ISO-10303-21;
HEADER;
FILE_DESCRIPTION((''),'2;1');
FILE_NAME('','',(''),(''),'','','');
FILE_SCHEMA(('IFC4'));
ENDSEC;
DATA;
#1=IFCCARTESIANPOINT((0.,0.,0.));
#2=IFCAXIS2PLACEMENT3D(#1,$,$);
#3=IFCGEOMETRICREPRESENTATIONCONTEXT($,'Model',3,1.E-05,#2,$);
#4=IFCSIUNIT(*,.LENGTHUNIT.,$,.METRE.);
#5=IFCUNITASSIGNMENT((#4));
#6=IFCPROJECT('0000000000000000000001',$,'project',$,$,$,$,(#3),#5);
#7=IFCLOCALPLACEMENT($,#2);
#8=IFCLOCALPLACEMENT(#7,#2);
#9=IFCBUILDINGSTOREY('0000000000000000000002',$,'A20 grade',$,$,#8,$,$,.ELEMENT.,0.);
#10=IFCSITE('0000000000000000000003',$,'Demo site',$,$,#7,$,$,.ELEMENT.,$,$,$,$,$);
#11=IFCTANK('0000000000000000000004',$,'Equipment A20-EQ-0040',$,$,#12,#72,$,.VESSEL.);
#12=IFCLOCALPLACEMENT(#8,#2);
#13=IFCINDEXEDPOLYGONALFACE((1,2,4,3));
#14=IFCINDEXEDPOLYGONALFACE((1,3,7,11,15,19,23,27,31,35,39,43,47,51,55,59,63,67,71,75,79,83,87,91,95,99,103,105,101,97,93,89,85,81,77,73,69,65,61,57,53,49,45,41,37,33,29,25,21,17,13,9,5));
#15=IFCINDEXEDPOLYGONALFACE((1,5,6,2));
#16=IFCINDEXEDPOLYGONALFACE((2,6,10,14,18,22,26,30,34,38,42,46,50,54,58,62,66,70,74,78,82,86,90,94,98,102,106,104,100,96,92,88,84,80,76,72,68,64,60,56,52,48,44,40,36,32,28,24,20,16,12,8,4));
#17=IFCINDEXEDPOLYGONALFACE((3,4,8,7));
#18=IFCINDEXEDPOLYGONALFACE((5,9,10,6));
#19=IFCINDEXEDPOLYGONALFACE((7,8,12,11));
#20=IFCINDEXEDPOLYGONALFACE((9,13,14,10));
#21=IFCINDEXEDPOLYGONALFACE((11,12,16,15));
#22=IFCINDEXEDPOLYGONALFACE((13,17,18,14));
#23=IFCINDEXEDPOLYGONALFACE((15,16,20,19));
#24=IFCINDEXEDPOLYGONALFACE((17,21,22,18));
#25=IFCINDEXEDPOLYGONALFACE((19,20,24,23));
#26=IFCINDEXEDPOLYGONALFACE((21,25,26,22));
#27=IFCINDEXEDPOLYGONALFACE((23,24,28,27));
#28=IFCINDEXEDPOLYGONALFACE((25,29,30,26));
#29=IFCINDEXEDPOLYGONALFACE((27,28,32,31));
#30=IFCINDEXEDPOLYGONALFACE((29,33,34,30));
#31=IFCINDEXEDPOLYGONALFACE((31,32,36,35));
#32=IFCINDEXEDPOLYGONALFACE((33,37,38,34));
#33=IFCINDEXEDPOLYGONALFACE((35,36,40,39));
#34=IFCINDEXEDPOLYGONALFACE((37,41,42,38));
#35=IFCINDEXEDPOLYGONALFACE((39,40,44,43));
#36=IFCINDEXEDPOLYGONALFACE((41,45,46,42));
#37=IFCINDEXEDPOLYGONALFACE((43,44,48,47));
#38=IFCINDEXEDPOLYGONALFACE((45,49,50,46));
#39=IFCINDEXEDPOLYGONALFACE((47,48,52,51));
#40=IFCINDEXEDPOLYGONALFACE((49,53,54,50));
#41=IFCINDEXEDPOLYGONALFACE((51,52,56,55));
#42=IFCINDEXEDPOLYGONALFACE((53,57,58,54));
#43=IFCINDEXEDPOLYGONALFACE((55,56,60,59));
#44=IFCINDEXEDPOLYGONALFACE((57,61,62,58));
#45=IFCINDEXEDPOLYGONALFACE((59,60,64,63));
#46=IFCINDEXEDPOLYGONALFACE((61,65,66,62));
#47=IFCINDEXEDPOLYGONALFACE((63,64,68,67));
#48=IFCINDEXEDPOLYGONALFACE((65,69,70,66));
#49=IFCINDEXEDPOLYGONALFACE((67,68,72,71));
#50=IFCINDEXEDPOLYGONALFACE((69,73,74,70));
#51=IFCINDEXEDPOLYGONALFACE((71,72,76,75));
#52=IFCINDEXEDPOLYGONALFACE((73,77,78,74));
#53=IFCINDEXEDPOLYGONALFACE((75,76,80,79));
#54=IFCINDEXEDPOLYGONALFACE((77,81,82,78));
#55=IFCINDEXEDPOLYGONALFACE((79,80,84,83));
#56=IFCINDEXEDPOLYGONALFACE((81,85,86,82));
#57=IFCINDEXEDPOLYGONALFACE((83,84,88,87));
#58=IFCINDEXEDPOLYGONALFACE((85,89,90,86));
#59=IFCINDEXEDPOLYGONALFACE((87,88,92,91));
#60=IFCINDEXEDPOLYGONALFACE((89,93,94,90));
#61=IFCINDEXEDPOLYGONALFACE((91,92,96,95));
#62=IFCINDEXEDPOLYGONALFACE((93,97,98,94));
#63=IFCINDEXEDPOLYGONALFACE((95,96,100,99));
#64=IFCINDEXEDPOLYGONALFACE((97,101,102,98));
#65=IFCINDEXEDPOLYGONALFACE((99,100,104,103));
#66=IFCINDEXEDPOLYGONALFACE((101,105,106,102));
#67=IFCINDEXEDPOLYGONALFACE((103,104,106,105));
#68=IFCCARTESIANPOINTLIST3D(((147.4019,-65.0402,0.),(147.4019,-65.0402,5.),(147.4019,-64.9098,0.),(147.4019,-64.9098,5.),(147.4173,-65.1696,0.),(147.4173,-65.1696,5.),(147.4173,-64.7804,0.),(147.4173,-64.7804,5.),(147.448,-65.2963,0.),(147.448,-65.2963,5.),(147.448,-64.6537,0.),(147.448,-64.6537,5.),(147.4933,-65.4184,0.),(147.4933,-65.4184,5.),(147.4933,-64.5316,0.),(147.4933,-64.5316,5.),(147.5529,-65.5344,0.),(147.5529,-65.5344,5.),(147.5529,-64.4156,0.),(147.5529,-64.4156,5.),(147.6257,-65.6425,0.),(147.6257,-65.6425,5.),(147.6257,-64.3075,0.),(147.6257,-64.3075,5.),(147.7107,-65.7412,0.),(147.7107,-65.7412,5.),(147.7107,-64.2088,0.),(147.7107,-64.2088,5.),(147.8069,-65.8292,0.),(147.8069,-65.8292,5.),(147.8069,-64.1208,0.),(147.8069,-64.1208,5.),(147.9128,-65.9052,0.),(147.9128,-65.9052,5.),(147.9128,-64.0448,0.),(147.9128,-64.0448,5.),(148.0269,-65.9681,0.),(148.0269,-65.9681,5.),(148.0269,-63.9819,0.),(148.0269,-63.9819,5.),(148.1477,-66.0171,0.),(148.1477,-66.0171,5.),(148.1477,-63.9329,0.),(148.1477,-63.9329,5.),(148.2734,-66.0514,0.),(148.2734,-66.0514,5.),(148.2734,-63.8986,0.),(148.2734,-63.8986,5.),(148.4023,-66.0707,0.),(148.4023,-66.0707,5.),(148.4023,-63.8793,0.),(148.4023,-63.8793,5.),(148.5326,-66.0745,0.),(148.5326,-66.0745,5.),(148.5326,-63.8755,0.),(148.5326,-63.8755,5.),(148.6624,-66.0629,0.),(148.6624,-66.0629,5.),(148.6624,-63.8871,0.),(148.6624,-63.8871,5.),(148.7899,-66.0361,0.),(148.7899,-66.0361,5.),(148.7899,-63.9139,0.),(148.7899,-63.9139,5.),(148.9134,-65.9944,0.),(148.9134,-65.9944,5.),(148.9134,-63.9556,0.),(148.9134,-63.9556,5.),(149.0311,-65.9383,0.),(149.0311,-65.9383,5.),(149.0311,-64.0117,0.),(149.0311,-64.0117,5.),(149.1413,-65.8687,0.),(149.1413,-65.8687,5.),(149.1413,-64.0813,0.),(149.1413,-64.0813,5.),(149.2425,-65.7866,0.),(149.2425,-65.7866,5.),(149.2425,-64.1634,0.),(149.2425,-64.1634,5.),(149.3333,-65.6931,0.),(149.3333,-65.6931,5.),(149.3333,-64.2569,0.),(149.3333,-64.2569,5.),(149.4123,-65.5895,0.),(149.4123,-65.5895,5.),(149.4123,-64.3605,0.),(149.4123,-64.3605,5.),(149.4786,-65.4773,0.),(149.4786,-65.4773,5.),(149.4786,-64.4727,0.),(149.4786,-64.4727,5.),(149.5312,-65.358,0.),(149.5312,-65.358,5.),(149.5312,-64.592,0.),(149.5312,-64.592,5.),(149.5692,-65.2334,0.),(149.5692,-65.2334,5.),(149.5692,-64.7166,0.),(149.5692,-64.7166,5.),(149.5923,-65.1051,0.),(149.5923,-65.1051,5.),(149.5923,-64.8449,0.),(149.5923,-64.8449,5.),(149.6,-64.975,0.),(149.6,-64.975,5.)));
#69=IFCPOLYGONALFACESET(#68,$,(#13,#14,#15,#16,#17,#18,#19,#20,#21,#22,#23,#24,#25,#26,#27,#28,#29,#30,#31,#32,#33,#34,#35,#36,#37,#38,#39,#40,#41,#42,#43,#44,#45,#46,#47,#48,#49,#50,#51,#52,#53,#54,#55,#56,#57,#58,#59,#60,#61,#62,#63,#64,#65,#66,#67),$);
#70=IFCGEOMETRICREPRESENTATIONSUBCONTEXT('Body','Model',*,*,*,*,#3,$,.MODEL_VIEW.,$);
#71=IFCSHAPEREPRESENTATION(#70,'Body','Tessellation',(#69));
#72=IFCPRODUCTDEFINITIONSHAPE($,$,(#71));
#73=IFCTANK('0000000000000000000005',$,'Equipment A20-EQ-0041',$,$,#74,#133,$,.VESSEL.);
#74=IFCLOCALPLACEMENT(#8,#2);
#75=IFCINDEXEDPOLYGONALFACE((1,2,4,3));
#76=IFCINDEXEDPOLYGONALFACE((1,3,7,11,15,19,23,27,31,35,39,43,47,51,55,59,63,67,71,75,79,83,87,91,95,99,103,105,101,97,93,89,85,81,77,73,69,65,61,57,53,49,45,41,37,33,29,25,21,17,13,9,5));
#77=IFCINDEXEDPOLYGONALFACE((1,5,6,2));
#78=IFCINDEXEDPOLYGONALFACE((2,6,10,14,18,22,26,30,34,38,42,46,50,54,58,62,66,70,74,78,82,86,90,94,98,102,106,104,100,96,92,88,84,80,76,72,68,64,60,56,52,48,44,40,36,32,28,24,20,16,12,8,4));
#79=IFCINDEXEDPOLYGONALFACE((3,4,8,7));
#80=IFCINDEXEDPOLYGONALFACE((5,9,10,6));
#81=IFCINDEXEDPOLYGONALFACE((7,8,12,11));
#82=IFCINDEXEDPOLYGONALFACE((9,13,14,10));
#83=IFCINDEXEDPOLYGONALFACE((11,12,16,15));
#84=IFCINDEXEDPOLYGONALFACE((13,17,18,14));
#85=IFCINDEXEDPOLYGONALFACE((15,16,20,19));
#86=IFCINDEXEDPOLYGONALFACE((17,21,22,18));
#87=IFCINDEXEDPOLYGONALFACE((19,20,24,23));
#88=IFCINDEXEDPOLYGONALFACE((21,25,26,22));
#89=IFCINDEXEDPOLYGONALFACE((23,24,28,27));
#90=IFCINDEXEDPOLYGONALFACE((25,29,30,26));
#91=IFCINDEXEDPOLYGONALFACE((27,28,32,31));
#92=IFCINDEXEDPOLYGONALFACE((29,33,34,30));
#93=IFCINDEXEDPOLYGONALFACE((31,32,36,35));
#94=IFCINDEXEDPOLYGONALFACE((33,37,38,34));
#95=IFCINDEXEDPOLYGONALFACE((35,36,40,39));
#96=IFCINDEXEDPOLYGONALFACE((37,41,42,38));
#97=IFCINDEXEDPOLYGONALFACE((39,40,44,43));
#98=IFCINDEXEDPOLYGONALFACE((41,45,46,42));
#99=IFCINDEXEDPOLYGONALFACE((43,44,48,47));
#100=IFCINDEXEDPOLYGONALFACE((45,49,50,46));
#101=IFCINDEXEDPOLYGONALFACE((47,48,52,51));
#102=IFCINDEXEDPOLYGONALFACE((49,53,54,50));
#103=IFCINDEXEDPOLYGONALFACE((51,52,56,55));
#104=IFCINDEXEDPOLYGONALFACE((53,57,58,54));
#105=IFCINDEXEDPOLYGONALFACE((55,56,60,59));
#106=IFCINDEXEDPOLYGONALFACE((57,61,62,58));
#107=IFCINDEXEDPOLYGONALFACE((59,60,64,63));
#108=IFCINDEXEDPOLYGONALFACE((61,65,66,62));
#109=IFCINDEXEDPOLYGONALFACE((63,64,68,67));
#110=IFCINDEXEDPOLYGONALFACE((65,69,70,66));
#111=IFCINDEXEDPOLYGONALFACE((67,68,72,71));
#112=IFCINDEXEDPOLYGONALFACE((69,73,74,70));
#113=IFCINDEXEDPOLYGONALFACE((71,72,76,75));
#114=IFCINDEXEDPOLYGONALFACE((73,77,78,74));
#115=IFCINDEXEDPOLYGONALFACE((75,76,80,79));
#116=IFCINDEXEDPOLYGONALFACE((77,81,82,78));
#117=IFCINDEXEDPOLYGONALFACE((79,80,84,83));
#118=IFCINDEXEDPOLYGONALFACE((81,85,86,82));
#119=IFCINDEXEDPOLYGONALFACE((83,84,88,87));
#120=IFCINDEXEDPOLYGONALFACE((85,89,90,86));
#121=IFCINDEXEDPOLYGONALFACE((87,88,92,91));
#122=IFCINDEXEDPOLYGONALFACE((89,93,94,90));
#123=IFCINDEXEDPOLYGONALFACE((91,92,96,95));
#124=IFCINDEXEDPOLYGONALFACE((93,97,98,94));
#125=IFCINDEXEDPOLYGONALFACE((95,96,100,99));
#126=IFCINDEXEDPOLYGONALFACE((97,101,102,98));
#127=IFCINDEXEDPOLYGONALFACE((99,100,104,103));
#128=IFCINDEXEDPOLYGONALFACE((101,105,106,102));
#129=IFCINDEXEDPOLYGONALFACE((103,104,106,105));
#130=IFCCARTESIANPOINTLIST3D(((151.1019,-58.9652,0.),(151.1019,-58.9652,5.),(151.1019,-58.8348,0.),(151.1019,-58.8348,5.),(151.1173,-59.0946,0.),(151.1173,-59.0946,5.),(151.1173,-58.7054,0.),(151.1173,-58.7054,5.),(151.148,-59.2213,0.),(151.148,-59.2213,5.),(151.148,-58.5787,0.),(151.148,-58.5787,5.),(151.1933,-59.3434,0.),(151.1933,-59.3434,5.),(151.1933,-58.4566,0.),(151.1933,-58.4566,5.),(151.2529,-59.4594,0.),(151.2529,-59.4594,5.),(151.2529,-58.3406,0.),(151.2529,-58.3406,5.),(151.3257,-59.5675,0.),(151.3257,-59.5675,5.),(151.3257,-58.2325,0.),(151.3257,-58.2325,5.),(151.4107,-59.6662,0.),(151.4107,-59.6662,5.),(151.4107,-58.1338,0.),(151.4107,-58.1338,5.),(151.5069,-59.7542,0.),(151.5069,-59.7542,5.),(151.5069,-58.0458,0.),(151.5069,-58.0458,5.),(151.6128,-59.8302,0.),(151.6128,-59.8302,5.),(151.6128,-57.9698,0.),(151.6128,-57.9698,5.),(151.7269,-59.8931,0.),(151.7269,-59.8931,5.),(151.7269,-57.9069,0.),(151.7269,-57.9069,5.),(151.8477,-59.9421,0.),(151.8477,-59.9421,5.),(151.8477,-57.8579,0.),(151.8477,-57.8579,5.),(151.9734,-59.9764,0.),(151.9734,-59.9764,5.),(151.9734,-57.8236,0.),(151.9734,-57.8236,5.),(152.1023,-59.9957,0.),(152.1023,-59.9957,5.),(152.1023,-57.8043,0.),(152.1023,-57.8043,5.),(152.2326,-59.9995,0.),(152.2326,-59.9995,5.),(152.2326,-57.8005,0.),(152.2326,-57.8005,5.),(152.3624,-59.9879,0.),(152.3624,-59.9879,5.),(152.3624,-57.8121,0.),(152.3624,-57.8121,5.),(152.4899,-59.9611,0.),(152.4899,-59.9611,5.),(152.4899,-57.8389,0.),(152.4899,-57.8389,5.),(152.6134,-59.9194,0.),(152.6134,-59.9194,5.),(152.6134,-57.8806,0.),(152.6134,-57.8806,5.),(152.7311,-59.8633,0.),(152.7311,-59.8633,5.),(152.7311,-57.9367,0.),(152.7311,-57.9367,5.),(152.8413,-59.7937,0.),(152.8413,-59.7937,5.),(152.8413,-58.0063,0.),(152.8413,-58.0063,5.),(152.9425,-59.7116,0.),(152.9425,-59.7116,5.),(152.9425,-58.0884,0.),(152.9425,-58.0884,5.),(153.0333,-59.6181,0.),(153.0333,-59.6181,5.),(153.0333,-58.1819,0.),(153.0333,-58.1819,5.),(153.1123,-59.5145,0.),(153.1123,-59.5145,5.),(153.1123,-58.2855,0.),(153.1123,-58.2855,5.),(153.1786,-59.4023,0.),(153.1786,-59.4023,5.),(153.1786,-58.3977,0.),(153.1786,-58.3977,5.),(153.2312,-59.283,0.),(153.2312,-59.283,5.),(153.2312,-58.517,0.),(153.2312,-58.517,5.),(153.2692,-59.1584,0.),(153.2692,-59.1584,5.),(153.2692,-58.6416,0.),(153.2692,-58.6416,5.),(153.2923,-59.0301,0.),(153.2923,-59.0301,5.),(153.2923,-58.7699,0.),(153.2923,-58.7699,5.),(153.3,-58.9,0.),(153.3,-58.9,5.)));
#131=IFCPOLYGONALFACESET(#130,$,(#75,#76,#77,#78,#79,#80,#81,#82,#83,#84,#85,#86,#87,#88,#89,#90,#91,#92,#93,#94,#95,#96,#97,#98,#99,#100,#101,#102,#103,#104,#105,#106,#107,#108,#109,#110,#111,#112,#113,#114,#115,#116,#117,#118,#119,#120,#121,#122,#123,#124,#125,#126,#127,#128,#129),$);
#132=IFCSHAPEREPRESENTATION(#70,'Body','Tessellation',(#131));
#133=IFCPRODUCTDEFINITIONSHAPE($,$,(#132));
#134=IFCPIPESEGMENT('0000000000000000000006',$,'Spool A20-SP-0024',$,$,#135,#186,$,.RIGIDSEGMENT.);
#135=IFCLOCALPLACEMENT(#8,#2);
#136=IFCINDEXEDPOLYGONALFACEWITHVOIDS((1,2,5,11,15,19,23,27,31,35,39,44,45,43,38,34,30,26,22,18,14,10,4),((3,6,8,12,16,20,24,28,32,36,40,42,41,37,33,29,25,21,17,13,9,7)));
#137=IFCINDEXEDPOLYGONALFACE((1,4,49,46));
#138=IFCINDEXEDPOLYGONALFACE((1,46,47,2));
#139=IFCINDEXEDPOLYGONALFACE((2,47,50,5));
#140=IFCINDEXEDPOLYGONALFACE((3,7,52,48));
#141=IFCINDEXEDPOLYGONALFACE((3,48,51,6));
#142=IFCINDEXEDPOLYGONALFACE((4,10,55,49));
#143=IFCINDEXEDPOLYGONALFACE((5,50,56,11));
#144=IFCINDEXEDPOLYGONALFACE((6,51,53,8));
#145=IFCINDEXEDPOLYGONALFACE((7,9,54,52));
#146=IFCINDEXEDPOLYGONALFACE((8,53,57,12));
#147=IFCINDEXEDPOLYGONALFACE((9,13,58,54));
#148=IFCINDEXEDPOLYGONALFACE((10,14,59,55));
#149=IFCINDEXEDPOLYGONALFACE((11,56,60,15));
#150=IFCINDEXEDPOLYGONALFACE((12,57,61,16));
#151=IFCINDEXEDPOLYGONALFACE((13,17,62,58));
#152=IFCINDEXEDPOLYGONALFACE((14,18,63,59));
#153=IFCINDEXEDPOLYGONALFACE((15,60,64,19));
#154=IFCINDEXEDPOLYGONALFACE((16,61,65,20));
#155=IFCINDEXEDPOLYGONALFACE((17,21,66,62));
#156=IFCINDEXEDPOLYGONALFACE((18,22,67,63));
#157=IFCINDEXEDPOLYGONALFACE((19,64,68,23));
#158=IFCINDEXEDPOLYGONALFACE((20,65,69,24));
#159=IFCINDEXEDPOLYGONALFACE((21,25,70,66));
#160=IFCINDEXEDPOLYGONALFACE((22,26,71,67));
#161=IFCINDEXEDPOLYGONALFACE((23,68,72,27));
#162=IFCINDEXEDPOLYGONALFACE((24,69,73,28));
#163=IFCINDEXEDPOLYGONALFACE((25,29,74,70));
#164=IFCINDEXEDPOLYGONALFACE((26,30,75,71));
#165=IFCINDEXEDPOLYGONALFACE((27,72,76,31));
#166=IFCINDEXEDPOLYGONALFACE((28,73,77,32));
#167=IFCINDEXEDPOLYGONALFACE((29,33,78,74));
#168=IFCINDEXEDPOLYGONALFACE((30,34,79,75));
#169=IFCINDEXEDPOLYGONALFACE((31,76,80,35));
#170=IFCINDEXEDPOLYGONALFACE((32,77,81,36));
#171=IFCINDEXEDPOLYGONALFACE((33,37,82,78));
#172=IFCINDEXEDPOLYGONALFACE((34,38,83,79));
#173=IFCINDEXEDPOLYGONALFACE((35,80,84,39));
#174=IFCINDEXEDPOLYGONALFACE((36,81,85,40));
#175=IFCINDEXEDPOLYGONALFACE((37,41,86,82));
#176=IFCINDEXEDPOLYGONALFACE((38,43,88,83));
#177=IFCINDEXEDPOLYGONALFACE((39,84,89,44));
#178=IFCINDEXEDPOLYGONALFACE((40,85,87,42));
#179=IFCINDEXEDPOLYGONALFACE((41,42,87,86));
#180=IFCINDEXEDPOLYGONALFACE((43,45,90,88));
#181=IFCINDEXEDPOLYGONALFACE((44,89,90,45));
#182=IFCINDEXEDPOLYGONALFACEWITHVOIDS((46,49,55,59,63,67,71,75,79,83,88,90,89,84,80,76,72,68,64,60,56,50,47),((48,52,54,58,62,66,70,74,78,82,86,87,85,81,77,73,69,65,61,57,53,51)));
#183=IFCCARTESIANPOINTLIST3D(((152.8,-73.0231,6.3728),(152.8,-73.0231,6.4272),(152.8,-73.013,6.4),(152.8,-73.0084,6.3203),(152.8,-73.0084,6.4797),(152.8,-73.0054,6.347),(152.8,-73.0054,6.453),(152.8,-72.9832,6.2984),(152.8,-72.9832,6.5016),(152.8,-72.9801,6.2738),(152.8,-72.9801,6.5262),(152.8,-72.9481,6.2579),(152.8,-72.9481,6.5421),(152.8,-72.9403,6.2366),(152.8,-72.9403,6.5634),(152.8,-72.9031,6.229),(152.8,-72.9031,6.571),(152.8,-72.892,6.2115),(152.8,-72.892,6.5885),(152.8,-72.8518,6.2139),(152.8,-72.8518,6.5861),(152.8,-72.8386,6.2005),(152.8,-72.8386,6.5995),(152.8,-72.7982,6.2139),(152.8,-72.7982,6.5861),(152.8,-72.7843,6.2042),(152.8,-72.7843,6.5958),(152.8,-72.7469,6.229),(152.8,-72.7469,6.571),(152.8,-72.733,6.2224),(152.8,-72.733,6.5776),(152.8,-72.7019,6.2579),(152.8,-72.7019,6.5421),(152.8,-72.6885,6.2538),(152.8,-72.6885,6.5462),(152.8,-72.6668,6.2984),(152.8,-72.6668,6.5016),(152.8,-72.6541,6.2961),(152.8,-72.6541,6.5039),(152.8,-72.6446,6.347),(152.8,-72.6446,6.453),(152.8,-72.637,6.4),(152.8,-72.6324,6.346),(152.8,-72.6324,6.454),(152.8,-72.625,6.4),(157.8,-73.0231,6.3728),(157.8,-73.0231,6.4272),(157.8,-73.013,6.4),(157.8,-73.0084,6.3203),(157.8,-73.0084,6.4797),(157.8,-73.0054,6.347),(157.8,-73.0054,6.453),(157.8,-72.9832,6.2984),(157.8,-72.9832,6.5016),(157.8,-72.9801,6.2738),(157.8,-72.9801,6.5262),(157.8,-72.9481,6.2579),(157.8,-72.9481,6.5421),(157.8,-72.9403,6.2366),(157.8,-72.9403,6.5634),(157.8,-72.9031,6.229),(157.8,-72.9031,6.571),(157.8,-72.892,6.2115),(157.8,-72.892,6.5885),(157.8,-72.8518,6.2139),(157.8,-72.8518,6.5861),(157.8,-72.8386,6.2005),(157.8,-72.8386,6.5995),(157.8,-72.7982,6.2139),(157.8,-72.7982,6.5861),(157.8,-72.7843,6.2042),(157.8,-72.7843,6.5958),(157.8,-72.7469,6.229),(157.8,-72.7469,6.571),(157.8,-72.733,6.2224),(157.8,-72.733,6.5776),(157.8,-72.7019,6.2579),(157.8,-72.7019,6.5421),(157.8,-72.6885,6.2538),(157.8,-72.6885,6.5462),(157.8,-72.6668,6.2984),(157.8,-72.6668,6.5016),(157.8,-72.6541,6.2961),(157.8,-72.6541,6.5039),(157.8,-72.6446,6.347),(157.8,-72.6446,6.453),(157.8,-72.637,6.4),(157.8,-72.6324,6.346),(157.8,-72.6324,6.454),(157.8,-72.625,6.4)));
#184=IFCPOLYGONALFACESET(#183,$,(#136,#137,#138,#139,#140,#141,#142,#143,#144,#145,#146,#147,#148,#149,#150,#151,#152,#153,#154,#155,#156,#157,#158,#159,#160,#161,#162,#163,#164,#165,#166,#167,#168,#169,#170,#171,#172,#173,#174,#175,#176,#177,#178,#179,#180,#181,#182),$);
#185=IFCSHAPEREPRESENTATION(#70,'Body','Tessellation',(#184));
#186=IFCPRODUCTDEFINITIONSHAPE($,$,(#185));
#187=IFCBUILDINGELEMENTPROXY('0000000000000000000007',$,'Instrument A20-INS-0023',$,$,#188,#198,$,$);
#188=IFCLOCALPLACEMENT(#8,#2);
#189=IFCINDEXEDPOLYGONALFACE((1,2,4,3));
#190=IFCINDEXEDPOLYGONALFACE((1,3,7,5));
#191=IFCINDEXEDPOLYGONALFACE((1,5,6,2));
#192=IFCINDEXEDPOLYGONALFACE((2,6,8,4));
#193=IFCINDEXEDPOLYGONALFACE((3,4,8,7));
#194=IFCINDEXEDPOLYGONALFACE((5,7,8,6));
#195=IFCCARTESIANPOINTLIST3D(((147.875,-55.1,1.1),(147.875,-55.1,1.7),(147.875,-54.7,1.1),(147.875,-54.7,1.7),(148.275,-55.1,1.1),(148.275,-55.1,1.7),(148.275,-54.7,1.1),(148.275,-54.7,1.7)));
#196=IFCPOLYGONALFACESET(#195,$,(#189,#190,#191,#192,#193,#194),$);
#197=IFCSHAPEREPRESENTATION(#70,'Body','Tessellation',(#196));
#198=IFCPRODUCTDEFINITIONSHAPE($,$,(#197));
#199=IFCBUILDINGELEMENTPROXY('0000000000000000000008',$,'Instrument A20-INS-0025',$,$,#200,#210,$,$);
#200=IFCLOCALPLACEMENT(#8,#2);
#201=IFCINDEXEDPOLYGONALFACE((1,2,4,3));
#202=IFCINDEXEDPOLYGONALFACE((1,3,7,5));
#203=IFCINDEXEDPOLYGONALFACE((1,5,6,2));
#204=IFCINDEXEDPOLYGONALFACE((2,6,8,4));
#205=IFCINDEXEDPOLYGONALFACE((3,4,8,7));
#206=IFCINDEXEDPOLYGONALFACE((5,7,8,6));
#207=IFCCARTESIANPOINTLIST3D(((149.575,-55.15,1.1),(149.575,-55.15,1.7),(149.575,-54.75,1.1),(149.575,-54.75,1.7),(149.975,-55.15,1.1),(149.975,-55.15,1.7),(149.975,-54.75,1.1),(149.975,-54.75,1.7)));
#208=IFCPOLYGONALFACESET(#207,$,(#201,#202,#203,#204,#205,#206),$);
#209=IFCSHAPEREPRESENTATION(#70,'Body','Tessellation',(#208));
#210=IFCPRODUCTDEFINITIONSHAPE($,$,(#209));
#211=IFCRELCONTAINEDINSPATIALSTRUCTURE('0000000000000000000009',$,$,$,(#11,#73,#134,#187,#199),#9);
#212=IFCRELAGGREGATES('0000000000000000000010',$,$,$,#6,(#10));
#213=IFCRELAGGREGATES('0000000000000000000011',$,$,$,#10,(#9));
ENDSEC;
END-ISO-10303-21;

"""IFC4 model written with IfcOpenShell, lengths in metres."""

from ifc_helpers import new_model, si_unit, frame, origin, place, context, subcontext, project, spatial, rectangle, circle, hollow_circle, extrude, element, save


model = new_model("IFC4")

# Units and contexts
model_context = context("Model", 3, precision=1e-05, world=origin())
body_context = subcontext(model_context, "Body", "Model", "MODEL_VIEW")
ifc_project = project(units=[si_unit("LENGTHUNIT", "METRE")], contexts=[model_context])

# Site, storey
site_placement = place(None, origin())
site = spatial("IfcSite", under=ifc_project, at=site_placement, Name="Demo site", CompositionType="ELEMENT")
storey_placement = place(site_placement, origin())
storey = spatial("IfcBuildingStorey", under=site, at=storey_placement, Name="A20 grade", CompositionType="ELEMENT", Elevation=0.0)

# Tanks
for number, where, name in (
    (1, (148.5, -64.975, 0.0), "Equipment A20-EQ-0040"),
    (2, (152.2, -58.9, 0.0), "Equipment A20-EQ-0041"),
):
    element("IfcTank", number, at=place(storey_placement, frame(where)), inside=storey, Name=name, PredefinedType="VESSEL", context=body_context, shape_type="SweptSolid", body=[
        extrude(circle(Radius=1.1), origin(), (0.0, 0.0, 1.0), 5.0),
    ])

# Pipe segment
pipe_segment_placement = place(storey_placement, frame((152.8, -72.825, 6.4)))
element("IfcPipeSegment", 3, at=pipe_segment_placement, inside=storey, Name="Spool A20-SP-0024", PredefinedType="RIGIDSEGMENT", context=body_context, shape_type="SweptSolid", body=[
    extrude(hollow_circle(Radius=0.2, WallThickness=0.012), frame((0.0, 0.0, 0.0), z_axis=(1.0, 0.0, 0.0), x_axis=(0.0, 1.0, 0.0)), (0.0, 0.0, 1.0), 5.0),
])

# Building element proxies
for number, where, name in (
    (4, (148.075, -54.9, 1.1), "Instrument A20-INS-0023"),
    (5, (149.775, -54.95, 1.1), "Instrument A20-INS-0025"),
):
    element("IfcBuildingElementProxy", number, at=place(storey_placement, frame(where)), inside=storey, Name=name, context=body_context, shape_type="SweptSolid", body=[
        extrude(rectangle(XDim=0.4, YDim=0.4), origin(), (0.0, 0.0, 1.0), 0.6),
    ])

save(model, "model.ifc")
